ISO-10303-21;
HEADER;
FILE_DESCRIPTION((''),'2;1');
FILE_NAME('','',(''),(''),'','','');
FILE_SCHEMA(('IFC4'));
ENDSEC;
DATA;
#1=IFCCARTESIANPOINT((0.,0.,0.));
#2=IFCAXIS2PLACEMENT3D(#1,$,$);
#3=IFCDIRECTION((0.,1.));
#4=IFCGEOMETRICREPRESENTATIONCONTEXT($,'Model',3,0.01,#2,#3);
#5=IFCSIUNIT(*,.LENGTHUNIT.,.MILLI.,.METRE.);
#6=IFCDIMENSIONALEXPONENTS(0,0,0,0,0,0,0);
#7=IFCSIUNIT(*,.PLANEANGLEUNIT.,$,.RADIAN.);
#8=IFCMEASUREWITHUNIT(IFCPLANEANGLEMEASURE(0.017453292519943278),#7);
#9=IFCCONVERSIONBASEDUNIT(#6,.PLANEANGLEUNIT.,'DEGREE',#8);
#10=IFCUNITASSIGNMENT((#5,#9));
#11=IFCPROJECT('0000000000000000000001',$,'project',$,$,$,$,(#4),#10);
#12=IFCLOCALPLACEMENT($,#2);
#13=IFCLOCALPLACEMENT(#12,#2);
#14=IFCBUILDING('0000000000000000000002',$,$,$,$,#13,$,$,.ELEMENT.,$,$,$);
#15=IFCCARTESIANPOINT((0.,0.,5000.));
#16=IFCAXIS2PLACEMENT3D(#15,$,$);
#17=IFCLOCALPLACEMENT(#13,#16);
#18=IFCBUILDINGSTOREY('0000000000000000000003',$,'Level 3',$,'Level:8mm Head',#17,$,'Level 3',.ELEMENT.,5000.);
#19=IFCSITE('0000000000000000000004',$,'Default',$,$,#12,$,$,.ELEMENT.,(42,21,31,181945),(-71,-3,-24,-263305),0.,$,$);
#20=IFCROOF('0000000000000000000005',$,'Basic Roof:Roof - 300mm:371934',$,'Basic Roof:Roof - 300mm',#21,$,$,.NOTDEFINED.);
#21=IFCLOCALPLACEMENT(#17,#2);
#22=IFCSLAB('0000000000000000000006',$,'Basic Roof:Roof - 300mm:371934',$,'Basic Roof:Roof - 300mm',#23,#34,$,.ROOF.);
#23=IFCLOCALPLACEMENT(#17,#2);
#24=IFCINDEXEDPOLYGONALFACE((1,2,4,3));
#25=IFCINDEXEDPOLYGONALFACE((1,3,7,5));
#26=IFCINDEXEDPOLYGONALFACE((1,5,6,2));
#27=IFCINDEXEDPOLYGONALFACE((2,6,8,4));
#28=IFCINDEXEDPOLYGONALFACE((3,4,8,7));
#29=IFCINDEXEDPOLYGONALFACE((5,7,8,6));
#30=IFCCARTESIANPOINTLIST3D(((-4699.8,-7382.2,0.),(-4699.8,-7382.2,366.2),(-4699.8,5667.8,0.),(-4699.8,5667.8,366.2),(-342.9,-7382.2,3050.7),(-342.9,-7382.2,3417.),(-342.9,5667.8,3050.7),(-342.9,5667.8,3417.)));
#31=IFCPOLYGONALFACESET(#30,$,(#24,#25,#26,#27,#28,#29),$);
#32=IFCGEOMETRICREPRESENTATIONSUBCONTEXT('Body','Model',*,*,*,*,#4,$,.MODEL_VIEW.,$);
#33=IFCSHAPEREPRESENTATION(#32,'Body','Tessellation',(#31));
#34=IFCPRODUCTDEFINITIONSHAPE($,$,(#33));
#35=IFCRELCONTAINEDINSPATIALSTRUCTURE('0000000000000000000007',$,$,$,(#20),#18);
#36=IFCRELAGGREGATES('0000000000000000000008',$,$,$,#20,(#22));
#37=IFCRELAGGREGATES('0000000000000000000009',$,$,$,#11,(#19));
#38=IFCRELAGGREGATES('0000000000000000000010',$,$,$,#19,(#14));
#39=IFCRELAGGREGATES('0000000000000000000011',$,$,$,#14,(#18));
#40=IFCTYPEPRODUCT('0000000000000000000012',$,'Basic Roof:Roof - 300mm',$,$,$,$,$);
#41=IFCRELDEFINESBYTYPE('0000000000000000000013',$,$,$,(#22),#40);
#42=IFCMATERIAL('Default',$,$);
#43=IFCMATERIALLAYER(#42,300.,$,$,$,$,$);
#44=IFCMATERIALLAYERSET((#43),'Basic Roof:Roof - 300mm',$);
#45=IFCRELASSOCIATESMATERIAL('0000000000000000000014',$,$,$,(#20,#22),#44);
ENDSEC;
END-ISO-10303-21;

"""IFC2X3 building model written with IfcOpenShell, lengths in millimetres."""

from ifc_helpers import new_model, entity, si_unit, converted_unit, direction, frame, frame_2d, origin, place, context, subcontext, project, spatial, rectangle, extrude, material, layer, layer_set, type_object, element, aggregate, save


model = new_model("IFC2X3")

# Units and contexts
model_context = context("Model", 3, precision=0.01, world=origin(), true_north=direction((0.0, 1.0)))
body_context = subcontext(model_context, "Body", "Model", "MODEL_VIEW")
ifc_project = project(units=[si_unit("LENGTHUNIT", "METRE", prefix="MILLI"), converted_unit("PLANEANGLEUNIT", "DEGREE", entity("IfcPlaneAngleMeasure", 0.017453292519943278), si_unit("PLANEANGLEUNIT", "RADIAN"), dimensions=[0, 0, 0, 0, 0, 0, 0])], contexts=[model_context])

# Site, building, storey
site_placement = place(None, origin())
site = spatial("IfcSite", under=ifc_project, at=site_placement, Name="Default", CompositionType="ELEMENT", RefLatitude=(42, 21, 31, 181945), RefLongitude=(-71, -3, -24, -263305), RefElevation=0.0)
building_placement = place(site_placement, origin())
building = spatial("IfcBuilding", under=site, at=building_placement, CompositionType="ELEMENT")
storey_placement = place(building_placement, frame((0.0, 0.0, 5000.0)))
storey = spatial("IfcBuildingStorey", under=building, at=storey_placement, Name="Level 3", ObjectType="Level:8mm Head", LongName="Level 3", CompositionType="ELEMENT", Elevation=5000.0)

# Roof, slab
ifc_material = material(Name="Default")
ifc_layer = layer(ifc_material, 300.0)
ifc_layer_set = layer_set([ifc_layer], Name="Basic Roof:Roof - 300mm")
roof_placement = place(storey_placement, frame((-4699.8, -7382.2, 0.0)))
roof = element("IfcRoof", 1, at=roof_placement, inside=storey, material=ifc_layer_set, Name="Basic Roof:Roof - 300mm:371934", ObjectType="Basic Roof:Roof - 300mm", ShapeType="NOTDEFINED")
type_product = type_object("IfcTypeProduct", Name="Basic Roof:Roof - 300mm")
slab_1_placement = place(roof_placement, origin())
slab_1 = element("IfcSlab", 2, at=slab_1_placement, type_object=type_product, material=ifc_layer_set, Name="Basic Roof:Roof - 300mm:371934", ObjectType="Basic Roof:Roof - 300mm", PredefinedType="ROOF", context=body_context, shape_type="SweptSolid", body=[
    extrude(rectangle(XDim=13050.0, YDim=5318.8, at=frame_2d((0.0, 0.0), x_axis=(0.0, 1.0))), frame((2178.4, 6525.0, 1525.4), z_axis=(-0.573576, 0.0, 0.819152), x_axis=(0.819152, 0.0, 0.573576)), (0.573576, 0.0, 0.819152), 366.2),
])
aggregate(roof, [slab_1])

save(model, "model.ifc")
